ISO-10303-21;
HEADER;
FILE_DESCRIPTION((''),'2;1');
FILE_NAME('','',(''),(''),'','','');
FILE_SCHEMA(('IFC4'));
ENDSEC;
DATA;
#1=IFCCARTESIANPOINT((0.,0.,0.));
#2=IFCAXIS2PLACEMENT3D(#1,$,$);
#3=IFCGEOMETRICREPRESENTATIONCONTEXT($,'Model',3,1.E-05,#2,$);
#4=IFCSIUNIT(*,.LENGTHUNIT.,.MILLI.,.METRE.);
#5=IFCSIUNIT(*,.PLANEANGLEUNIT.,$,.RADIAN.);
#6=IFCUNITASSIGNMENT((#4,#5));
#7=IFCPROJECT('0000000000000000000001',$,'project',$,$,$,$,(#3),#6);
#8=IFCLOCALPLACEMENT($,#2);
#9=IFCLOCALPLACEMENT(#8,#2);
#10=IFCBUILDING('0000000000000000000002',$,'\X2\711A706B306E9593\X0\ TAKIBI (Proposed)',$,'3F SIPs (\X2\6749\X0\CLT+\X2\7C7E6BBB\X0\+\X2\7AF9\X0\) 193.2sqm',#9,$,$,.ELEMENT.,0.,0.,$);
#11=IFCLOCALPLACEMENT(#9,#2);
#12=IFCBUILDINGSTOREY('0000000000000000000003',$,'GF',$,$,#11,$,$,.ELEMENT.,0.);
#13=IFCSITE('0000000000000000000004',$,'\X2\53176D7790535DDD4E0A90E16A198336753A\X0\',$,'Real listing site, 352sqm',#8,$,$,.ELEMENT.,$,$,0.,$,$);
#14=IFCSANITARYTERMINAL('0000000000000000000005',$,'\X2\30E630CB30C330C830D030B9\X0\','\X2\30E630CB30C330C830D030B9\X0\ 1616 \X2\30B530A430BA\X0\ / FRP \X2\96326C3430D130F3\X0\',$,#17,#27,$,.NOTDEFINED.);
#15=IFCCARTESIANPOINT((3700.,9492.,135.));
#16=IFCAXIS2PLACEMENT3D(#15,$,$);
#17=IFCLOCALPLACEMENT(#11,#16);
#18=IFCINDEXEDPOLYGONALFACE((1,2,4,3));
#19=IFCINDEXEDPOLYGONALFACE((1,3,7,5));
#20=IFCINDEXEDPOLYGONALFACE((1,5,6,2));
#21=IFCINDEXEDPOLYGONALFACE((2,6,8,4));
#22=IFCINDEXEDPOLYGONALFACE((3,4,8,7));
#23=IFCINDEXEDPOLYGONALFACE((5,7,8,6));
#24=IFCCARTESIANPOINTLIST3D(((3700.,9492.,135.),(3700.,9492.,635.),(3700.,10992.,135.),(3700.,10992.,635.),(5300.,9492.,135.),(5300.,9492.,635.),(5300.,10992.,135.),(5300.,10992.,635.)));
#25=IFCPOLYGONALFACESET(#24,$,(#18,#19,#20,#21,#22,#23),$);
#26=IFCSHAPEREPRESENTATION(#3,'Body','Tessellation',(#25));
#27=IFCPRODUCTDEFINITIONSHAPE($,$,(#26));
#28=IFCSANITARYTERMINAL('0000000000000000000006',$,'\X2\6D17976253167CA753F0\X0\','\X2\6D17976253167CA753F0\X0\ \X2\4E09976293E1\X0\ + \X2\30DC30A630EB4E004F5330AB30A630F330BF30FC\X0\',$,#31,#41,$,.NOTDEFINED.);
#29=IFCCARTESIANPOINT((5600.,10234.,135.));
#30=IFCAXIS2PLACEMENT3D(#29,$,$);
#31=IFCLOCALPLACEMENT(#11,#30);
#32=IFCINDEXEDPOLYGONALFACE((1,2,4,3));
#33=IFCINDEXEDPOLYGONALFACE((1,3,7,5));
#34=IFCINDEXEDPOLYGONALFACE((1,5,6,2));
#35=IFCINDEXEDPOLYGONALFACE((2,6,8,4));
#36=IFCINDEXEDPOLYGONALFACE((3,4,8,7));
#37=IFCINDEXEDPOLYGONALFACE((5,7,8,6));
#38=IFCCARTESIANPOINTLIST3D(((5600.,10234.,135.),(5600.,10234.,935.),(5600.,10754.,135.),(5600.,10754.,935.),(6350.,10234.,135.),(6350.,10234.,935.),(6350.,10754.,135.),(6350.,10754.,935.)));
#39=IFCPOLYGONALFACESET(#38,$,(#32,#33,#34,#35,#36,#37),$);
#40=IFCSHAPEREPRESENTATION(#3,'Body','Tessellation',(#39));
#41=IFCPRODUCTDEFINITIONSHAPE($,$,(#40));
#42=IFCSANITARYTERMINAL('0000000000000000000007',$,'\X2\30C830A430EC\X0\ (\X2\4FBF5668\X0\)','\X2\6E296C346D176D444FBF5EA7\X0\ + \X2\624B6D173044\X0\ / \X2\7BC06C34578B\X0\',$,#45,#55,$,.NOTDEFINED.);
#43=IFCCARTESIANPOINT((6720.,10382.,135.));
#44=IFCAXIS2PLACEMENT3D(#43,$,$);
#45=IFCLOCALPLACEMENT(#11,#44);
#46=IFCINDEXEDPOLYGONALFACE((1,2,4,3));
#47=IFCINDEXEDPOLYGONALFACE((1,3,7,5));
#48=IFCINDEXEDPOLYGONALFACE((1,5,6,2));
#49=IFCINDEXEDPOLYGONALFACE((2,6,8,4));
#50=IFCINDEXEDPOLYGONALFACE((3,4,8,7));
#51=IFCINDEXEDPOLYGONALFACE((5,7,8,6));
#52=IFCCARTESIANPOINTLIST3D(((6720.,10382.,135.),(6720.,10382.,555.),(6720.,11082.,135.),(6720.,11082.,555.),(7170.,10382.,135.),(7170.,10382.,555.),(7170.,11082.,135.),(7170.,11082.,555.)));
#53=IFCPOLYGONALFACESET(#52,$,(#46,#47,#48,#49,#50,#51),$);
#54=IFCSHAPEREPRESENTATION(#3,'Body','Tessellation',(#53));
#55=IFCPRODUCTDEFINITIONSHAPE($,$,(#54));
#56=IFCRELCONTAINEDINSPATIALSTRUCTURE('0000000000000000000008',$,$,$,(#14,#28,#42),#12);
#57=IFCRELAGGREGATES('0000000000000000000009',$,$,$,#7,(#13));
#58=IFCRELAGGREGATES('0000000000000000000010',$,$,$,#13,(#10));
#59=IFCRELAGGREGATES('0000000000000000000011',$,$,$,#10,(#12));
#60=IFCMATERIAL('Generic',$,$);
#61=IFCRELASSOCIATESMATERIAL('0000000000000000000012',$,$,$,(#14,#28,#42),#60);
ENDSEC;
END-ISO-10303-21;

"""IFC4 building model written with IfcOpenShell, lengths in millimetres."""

from ifc_helpers import new_model, si_unit, frame, frame_2d, origin, place, context, project, spatial, rectangle, extrude, material, element, save


model = new_model("IFC4")

# Units and contexts
model_context = context("Model", 3, precision=1e-05, world=origin())
ifc_project = project(units=[si_unit("LENGTHUNIT", "METRE", prefix="MILLI"), si_unit("PLANEANGLEUNIT", "RADIAN")], contexts=[model_context])

# Site, building, storey
site_placement = place(None, origin())
site = spatial("IfcSite", under=ifc_project, at=site_placement, Name="北海道川上郡標茶町", ObjectType="Real listing site, 352sqm", CompositionType="ELEMENT", RefElevation=0.0)
building_placement = place(site_placement, origin())
building = spatial("IfcBuilding", under=site, at=building_placement, Name="焚火の間 TAKIBI (Proposed)", ObjectType="3F SIPs (杉CLT+籾殻+竹) 193.2sqm", CompositionType="ELEMENT", ElevationOfRefHeight=0.0, ElevationOfTerrain=0.0)
storey_placement = place(building_placement, origin())
storey = spatial("IfcBuildingStorey", under=building, at=storey_placement, Name="GF", CompositionType="ELEMENT", Elevation=0.0)

# Shared definitions
ifc_material_1 = material(Name="Generic")

# Sanitary terminals
sanitary_terminal_1_placement = place(storey_placement, frame((3700.0, 9492.0, 135.0)))
element("IfcSanitaryTerminal", 1, at=sanitary_terminal_1_placement, inside=storey, material=ifc_material_1, Name="ユニットバス", Description="ユニットバス 1616 サイズ / FRP 防水パン", PredefinedType="NOTDEFINED", context=model_context, shape_type="SweptSolid", body=[
    extrude(rectangle(XDim=1600.0, YDim=1500.0, at=frame_2d((800.0, 750.0))), frame((3700.0, 9492.0, 135.0)), (0.0, 0.0, 1.0), 500.0),
])
sanitary_terminal_2_placement = place(storey_placement, frame((5600.0, 10234.0, 135.0)))
element("IfcSanitaryTerminal", 2, at=sanitary_terminal_2_placement, inside=storey, material=ifc_material_1, Name="洗面化粧台", Description="洗面化粧台 三面鏡 + ボウル一体カウンター", PredefinedType="NOTDEFINED", context=model_context, shape_type="SweptSolid", body=[
    extrude(rectangle(XDim=750.0, YDim=520.0, at=frame_2d((375.0, 260.0))), frame((5600.0, 10234.0, 135.0)), (0.0, 0.0, 1.0), 800.0),
])
sanitary_terminal_3_placement = place(storey_placement, frame((6720.0, 10382.0, 135.0)))
element("IfcSanitaryTerminal", 3, at=sanitary_terminal_3_placement, inside=storey, material=ifc_material_1, Name="トイレ (便器)", Description="温水洗浄便座 + 手洗い / 節水型", PredefinedType="NOTDEFINED", context=model_context, shape_type="SweptSolid", body=[
    extrude(rectangle(XDim=450.0, YDim=700.0, at=frame_2d((225.0, 350.0))), frame((6720.0, 10382.0, 135.0)), (0.0, 0.0, 1.0), 420.0),
])

save(model, "model.ifc")
